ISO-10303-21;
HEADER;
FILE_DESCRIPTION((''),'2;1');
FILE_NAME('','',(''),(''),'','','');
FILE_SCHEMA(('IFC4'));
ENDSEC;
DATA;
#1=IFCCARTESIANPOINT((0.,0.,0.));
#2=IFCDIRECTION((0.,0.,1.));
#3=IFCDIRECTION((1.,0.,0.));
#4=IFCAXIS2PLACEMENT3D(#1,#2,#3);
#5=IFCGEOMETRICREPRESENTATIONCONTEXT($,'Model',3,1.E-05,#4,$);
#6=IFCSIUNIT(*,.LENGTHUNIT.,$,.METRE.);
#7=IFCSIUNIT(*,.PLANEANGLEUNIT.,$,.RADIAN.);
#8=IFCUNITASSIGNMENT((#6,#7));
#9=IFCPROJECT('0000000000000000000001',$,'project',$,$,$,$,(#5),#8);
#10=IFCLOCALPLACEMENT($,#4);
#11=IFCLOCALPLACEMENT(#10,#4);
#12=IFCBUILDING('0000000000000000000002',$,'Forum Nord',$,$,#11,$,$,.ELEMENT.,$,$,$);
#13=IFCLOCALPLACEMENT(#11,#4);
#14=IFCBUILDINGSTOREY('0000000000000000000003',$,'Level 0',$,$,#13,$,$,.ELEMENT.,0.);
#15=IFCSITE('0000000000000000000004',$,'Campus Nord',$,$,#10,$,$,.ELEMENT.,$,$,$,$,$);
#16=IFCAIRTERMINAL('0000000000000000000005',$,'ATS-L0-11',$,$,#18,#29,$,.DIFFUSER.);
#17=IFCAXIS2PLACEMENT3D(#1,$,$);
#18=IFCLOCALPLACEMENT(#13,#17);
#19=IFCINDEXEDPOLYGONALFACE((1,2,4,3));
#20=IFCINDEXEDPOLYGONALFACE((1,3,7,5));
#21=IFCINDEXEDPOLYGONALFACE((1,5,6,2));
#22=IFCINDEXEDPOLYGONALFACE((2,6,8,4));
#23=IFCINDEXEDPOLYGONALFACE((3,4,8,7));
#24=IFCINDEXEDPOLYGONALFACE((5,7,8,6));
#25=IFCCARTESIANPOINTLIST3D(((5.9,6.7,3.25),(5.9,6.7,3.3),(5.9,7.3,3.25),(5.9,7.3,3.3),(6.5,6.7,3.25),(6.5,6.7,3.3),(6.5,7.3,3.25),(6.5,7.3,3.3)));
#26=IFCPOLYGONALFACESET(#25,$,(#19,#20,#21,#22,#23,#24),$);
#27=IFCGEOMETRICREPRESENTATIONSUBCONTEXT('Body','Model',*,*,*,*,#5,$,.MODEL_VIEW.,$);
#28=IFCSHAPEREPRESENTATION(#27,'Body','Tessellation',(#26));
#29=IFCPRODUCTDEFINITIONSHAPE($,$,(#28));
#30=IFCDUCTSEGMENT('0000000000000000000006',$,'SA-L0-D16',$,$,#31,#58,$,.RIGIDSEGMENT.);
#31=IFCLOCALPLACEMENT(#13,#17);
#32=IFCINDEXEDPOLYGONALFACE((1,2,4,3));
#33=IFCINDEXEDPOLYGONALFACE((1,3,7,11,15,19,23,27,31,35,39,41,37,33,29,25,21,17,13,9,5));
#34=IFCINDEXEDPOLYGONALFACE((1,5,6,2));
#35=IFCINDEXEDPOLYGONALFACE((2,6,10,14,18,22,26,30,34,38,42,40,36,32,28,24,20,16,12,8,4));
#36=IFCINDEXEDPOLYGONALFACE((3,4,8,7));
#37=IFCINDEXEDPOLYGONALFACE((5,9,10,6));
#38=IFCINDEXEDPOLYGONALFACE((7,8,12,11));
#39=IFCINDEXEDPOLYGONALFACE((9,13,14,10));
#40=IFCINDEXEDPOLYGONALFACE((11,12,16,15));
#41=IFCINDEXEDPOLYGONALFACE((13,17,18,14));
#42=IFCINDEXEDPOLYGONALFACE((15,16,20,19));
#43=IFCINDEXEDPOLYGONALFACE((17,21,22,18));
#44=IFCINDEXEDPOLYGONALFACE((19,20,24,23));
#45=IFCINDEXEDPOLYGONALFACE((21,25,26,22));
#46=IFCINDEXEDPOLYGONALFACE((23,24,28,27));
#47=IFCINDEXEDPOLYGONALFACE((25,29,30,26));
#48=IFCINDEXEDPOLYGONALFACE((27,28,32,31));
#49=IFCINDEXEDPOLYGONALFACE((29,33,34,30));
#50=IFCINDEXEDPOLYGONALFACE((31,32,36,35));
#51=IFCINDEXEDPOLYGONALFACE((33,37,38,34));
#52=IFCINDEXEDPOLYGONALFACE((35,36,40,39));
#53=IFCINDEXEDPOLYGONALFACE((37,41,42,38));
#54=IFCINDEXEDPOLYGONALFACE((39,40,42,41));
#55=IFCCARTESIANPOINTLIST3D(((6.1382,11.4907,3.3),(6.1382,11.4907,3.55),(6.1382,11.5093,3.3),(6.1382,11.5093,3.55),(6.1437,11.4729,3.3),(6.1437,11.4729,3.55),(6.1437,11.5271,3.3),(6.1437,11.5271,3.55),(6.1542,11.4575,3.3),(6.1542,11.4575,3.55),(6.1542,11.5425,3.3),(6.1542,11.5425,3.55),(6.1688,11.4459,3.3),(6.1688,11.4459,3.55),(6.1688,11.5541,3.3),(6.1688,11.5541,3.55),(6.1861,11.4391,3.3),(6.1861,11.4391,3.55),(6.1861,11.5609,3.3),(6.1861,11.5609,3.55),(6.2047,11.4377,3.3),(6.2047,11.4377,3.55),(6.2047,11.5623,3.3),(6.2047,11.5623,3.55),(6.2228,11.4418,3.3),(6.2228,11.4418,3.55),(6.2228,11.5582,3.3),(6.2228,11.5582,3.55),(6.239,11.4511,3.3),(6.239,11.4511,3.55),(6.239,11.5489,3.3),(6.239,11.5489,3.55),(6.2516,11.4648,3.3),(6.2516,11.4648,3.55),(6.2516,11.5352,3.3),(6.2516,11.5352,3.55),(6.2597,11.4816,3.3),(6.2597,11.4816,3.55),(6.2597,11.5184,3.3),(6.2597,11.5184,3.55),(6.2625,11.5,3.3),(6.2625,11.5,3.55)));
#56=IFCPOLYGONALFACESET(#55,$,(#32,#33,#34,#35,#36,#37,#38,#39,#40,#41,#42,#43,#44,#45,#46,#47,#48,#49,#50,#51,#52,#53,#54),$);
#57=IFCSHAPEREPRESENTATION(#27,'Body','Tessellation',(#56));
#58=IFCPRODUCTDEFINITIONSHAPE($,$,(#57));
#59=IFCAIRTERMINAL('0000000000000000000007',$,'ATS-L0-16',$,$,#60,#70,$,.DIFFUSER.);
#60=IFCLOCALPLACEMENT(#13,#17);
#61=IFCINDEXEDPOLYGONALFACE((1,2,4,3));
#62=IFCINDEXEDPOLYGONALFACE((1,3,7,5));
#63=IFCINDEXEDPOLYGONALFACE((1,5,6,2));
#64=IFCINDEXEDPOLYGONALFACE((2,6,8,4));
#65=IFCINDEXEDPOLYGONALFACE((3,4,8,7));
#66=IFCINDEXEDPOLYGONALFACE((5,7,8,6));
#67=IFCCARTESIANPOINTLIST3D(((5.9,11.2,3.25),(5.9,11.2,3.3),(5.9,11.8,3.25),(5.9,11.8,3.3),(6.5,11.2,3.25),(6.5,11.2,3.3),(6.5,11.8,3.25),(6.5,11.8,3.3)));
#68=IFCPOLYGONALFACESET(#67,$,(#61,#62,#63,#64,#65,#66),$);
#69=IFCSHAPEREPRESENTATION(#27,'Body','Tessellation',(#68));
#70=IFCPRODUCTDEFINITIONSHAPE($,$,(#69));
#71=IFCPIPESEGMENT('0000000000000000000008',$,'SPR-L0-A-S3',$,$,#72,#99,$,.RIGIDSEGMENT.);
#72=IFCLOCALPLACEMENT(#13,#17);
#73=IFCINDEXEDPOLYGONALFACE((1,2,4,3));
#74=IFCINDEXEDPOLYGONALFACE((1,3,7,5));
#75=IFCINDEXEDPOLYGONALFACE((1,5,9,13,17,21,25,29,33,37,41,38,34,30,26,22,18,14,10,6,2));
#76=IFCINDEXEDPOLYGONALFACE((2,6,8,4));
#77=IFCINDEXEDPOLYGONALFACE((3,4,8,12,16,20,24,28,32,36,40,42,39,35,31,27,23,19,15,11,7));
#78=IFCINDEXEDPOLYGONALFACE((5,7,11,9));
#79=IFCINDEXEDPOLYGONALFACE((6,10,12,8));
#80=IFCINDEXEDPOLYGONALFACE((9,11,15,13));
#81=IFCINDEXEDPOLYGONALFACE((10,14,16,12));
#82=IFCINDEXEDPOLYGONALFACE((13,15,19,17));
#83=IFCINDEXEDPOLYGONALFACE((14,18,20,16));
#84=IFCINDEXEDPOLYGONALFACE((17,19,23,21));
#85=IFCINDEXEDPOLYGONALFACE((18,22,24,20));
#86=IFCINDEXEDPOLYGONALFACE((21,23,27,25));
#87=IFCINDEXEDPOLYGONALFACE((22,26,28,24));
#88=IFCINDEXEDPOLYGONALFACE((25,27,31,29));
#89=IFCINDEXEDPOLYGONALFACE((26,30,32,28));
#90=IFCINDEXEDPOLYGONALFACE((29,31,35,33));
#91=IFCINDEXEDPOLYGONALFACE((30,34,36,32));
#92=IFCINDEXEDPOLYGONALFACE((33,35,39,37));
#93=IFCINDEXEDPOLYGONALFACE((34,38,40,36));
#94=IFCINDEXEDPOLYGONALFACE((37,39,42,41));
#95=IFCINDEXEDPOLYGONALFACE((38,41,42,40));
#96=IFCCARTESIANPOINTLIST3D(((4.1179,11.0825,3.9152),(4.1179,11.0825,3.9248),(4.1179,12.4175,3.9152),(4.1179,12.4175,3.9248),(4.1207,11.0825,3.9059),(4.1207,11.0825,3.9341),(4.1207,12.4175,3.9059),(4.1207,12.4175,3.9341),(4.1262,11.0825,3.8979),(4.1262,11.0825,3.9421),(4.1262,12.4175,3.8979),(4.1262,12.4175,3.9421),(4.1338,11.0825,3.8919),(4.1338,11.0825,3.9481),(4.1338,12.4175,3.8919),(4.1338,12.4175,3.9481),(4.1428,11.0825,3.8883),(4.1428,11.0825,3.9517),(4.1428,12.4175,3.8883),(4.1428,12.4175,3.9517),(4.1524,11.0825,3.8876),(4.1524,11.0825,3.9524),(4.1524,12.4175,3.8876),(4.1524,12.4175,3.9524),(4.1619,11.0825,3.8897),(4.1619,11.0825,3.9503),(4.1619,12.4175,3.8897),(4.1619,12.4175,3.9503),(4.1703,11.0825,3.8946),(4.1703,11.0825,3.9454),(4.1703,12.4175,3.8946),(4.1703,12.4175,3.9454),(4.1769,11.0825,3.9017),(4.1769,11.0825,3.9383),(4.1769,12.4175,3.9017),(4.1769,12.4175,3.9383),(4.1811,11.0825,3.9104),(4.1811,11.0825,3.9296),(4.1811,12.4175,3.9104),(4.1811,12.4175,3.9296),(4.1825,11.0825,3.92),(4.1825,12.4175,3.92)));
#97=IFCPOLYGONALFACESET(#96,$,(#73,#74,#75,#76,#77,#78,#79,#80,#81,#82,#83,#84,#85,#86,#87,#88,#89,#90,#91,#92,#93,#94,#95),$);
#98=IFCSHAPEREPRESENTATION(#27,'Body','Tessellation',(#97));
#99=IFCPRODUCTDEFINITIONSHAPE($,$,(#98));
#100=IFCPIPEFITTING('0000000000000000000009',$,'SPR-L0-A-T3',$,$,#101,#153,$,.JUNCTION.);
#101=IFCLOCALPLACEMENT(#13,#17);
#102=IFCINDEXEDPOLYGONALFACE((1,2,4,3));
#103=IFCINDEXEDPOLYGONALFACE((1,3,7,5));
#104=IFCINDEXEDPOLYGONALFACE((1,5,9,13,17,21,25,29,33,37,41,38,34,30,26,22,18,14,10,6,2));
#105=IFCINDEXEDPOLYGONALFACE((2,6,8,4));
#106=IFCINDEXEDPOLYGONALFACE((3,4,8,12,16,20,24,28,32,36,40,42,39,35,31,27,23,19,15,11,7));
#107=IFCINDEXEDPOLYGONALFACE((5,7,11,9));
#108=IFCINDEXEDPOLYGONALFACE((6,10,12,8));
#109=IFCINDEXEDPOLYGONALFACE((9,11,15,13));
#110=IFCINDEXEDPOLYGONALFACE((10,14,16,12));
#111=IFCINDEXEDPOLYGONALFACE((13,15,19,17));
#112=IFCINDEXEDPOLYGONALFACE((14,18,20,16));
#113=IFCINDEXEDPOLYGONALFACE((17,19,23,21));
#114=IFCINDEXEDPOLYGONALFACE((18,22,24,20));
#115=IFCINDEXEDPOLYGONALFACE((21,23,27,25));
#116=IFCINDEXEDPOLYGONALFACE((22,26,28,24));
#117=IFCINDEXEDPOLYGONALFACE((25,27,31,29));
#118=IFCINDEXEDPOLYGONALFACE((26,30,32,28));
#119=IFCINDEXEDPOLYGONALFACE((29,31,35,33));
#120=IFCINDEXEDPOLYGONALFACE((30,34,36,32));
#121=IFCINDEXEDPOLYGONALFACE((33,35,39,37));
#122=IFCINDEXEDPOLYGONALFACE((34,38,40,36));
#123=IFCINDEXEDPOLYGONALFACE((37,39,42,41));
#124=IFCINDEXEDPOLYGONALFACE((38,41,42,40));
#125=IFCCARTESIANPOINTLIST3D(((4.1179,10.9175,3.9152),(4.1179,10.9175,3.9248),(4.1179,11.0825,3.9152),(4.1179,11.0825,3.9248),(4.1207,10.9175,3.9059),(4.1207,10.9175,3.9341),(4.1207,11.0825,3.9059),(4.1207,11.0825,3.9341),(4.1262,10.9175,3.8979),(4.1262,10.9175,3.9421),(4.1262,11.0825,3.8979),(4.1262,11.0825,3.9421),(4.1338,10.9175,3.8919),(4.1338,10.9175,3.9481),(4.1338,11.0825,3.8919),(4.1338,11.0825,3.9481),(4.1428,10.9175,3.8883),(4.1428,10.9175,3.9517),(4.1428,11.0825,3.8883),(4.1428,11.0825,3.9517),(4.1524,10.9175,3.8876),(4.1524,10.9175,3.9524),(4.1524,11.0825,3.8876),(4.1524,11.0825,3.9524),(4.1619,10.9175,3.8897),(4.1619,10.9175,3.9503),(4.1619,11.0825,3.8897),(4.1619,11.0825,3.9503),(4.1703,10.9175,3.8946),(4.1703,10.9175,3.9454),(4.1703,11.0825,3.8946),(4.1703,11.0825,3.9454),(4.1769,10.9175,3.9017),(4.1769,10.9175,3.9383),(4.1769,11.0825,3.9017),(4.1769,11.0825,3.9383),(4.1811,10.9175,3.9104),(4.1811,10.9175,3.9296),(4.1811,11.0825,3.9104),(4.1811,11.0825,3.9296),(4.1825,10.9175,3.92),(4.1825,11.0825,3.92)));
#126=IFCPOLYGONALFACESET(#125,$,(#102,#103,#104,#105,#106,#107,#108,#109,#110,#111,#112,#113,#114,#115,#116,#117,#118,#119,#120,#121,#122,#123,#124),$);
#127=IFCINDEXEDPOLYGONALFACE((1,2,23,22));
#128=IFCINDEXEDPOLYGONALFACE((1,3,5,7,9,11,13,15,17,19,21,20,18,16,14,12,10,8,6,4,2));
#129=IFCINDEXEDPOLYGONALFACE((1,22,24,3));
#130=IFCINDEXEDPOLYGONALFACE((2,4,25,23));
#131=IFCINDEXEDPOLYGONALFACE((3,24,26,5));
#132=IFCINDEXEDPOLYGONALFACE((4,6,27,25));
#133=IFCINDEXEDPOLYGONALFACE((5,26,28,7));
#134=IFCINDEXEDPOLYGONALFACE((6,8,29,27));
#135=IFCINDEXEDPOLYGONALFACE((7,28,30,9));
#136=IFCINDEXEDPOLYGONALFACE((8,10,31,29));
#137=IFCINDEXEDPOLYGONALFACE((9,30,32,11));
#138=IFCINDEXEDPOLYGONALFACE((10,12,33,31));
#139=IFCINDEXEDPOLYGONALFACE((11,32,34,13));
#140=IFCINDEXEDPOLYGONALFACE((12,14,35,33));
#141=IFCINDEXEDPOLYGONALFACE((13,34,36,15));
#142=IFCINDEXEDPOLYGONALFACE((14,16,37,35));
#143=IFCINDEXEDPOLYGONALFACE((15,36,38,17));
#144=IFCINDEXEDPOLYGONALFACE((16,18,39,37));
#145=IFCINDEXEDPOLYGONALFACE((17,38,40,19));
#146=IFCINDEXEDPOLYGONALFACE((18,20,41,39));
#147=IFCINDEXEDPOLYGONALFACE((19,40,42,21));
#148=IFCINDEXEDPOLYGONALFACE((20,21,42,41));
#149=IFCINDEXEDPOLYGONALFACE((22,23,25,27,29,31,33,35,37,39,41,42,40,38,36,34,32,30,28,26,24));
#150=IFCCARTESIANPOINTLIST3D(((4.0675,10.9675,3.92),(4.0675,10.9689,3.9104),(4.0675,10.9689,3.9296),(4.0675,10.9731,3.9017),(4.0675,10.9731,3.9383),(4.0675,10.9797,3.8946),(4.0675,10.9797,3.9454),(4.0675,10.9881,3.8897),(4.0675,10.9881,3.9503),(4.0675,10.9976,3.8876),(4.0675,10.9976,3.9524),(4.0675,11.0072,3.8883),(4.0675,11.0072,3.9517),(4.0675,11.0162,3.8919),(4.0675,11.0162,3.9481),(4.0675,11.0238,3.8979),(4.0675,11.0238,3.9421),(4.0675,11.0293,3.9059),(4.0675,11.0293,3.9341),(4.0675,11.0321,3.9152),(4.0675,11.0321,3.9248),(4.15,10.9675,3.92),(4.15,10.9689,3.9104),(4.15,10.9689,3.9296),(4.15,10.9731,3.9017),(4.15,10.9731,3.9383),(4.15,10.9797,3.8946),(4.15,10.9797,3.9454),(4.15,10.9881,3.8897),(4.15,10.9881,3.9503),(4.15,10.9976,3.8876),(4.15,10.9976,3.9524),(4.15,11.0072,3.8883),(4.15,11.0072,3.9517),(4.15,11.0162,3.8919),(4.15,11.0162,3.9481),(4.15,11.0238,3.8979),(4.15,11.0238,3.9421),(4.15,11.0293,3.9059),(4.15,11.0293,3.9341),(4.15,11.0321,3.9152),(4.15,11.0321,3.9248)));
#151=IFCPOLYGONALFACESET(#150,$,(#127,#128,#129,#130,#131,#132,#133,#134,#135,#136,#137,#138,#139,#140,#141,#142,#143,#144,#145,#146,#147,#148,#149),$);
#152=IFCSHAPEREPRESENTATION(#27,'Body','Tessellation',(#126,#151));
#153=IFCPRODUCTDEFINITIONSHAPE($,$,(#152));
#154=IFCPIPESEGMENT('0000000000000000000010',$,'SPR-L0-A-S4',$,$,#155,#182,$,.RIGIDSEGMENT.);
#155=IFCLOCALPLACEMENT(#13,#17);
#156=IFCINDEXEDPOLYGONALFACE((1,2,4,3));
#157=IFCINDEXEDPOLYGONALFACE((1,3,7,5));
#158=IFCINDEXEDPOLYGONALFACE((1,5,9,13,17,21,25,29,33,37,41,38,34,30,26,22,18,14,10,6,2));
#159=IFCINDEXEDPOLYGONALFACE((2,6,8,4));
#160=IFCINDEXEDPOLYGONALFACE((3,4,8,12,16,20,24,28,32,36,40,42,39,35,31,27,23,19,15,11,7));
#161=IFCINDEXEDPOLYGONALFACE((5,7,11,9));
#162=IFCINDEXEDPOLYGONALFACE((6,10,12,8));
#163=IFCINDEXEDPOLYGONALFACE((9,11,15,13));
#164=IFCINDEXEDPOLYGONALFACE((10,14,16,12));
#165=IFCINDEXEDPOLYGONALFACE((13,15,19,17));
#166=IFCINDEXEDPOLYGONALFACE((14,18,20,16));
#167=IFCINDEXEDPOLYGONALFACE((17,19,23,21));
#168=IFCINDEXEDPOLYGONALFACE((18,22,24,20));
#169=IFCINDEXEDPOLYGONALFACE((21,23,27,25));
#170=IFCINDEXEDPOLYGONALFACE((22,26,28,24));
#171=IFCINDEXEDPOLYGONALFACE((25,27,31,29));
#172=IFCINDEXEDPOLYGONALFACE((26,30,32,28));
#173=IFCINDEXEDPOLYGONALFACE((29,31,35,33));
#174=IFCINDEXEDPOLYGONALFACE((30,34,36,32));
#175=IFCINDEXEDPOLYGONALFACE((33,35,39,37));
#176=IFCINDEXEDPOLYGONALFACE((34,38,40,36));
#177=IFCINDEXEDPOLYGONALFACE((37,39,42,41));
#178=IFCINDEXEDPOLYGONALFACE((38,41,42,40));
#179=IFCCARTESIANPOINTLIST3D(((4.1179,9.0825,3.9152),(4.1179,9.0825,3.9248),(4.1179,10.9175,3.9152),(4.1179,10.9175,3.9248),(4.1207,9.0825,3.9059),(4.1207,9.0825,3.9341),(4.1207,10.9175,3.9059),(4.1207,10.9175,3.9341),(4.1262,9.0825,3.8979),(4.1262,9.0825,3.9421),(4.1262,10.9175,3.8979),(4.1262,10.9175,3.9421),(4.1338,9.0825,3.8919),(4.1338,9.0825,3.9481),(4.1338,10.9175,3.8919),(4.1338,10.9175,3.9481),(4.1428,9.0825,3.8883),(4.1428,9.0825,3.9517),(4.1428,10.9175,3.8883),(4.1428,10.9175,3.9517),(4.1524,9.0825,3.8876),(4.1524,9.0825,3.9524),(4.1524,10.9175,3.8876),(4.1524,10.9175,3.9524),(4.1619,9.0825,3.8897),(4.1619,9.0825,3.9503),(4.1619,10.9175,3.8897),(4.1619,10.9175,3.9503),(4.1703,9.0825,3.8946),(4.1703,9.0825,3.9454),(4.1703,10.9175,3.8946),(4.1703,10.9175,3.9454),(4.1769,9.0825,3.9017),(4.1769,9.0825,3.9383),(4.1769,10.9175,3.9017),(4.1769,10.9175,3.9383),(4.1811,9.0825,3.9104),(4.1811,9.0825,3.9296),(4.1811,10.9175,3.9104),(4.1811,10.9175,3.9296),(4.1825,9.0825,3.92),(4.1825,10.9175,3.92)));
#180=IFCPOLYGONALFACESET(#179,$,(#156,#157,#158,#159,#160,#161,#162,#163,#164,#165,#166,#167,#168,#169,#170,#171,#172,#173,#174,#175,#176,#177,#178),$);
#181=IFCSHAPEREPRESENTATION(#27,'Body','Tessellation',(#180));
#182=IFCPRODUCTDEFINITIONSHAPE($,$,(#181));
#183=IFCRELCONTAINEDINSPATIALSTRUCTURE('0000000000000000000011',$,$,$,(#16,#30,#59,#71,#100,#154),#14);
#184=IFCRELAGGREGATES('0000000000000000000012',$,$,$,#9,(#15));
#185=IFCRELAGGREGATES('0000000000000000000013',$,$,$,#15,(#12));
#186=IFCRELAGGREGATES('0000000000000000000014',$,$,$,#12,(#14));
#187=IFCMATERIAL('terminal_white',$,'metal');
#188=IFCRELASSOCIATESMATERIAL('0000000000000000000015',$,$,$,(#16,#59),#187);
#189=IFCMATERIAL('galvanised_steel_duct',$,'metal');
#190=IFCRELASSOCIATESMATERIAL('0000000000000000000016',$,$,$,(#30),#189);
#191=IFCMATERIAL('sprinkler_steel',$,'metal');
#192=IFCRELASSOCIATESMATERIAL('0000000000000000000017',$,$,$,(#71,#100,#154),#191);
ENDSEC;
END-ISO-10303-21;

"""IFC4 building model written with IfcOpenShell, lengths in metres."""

from ifc_helpers import new_model, si_unit, frame, origin_with_axes, origin_2d_with_axis, place, context, subcontext, project, spatial, rectangle, circle, extrude, material, element, save


model = new_model("IFC4")

# Units and contexts
model_context = context("Model", 3, precision=1e-05, world=origin_with_axes())
body_context = subcontext(model_context, "Body", "Model", "MODEL_VIEW")
ifc_project = project(units=[si_unit("LENGTHUNIT", "METRE"), si_unit("PLANEANGLEUNIT", "RADIAN")], contexts=[model_context])

# Site, building, storey
site_placement = place(None, origin_with_axes())
site = spatial("IfcSite", under=ifc_project, at=site_placement, Name="Campus Nord", CompositionType="ELEMENT")
building_placement = place(site_placement, origin_with_axes())
building = spatial("IfcBuilding", under=site, at=building_placement, Name="Forum Nord", CompositionType="ELEMENT")
storey_placement = place(building_placement, origin_with_axes())
storey = spatial("IfcBuildingStorey", under=building, at=storey_placement, Name="Level 0", CompositionType="ELEMENT", Elevation=0.0)

# Shared definitions
ifc_material_1 = material(Name="galvanised_steel_duct", Category="metal")

# Air terminal
ifc_material_2 = material(Name="terminal_white", Category="metal")
air_terminal_1_placement = place(storey_placement, frame((6.2, 7.0, 3.25), z_axis=(0.0, 0.0, 1.0), x_axis=(1.0, 0.0, 0.0)))
element("IfcAirTerminal", 1, at=air_terminal_1_placement, inside=storey, material=ifc_material_2, Name="ATS-L0-11", PredefinedType="DIFFUSER", context=body_context, shape_type="SweptSolid", body=[
    extrude(rectangle(XDim=0.6, YDim=0.6, at=origin_2d_with_axis()), origin_with_axes(), (0.0, 0.0, 1.0), 0.05),
])

# Duct segment
duct_segment_1_placement = place(storey_placement, frame((6.2, 11.5, 3.55), z_axis=(0.0, 0.0, -1.0), x_axis=(1.0, 0.0, 0.0)))
element("IfcDuctSegment", 2, at=duct_segment_1_placement, inside=storey, material=ifc_material_1, Name="SA-L0-D16", PredefinedType="RIGIDSEGMENT", context=body_context, shape_type="SweptSolid", body=[
    extrude(circle(Radius=0.0625, at=origin_2d_with_axis()), origin_with_axes(), (0.0, 0.0, 1.0), 0.25),
])

# Air terminal
air_terminal_2_placement = place(storey_placement, frame((6.2, 11.5, 3.25), z_axis=(0.0, 0.0, 1.0), x_axis=(1.0, 0.0, 0.0)))
element("IfcAirTerminal", 3, at=air_terminal_2_placement, inside=storey, material=ifc_material_2, Name="ATS-L0-16", PredefinedType="DIFFUSER", context=body_context, shape_type="SweptSolid", body=[
    extrude(rectangle(XDim=0.6, YDim=0.6, at=origin_2d_with_axis()), origin_with_axes(), (0.0, 0.0, 1.0), 0.05),
])

# Pipe segment
ifc_material_3 = material(Name="sprinkler_steel", Category="metal")
pipe_segment_1_placement = place(storey_placement, frame((4.15, 12.4175, 3.92), z_axis=(0.0, -1.0, 0.0), x_axis=(1.0, 0.0, 0.0)))
element("IfcPipeSegment", 4, at=pipe_segment_1_placement, inside=storey, material=ifc_material_3, Name="SPR-L0-A-S3", PredefinedType="RIGIDSEGMENT", context=body_context, shape_type="SweptSolid", body=[
    extrude(circle(Radius=0.0325, at=origin_2d_with_axis()), origin_with_axes(), (0.0, 0.0, 1.0), 1.335),
])

# Pipe fitting
pipe_fitting_1_placement = place(storey_placement, frame((4.15, 11.0825, 3.92), z_axis=(0.0, -1.0, 0.0), x_axis=(1.0, 0.0, 0.0)))
element("IfcPipeFitting", 5, at=pipe_fitting_1_placement, inside=storey, material=ifc_material_3, Name="SPR-L0-A-T3", PredefinedType="JUNCTION", context=body_context, shape_type="SweptSolid", body=[
    extrude(circle(Radius=0.0325, at=origin_2d_with_axis()), origin_with_axes(), (0.0, 0.0, 1.0), 0.165),
    extrude(circle(Radius=0.0325, at=origin_2d_with_axis()), frame((0.0, 0.0, 0.0825), z_axis=(-1.0, 0.0, 0.0), x_axis=(0.0, 0.0, 1.0)), (0.0, 0.0, 1.0), 0.0825),
])

# Pipe segment
pipe_segment_2_placement = place(storey_placement, frame((4.15, 10.9175, 3.92), z_axis=(0.0, -1.0, 0.0), x_axis=(1.0, 0.0, 0.0)))
element("IfcPipeSegment", 6, at=pipe_segment_2_placement, inside=storey, material=ifc_material_3, Name="SPR-L0-A-S4", PredefinedType="RIGIDSEGMENT", context=body_context, shape_type="SweptSolid", body=[
    extrude(circle(Radius=0.0325, at=origin_2d_with_axis()), origin_with_axes(), (0.0, 0.0, 1.0), 1.835),
])

save(model, "model.ifc")
